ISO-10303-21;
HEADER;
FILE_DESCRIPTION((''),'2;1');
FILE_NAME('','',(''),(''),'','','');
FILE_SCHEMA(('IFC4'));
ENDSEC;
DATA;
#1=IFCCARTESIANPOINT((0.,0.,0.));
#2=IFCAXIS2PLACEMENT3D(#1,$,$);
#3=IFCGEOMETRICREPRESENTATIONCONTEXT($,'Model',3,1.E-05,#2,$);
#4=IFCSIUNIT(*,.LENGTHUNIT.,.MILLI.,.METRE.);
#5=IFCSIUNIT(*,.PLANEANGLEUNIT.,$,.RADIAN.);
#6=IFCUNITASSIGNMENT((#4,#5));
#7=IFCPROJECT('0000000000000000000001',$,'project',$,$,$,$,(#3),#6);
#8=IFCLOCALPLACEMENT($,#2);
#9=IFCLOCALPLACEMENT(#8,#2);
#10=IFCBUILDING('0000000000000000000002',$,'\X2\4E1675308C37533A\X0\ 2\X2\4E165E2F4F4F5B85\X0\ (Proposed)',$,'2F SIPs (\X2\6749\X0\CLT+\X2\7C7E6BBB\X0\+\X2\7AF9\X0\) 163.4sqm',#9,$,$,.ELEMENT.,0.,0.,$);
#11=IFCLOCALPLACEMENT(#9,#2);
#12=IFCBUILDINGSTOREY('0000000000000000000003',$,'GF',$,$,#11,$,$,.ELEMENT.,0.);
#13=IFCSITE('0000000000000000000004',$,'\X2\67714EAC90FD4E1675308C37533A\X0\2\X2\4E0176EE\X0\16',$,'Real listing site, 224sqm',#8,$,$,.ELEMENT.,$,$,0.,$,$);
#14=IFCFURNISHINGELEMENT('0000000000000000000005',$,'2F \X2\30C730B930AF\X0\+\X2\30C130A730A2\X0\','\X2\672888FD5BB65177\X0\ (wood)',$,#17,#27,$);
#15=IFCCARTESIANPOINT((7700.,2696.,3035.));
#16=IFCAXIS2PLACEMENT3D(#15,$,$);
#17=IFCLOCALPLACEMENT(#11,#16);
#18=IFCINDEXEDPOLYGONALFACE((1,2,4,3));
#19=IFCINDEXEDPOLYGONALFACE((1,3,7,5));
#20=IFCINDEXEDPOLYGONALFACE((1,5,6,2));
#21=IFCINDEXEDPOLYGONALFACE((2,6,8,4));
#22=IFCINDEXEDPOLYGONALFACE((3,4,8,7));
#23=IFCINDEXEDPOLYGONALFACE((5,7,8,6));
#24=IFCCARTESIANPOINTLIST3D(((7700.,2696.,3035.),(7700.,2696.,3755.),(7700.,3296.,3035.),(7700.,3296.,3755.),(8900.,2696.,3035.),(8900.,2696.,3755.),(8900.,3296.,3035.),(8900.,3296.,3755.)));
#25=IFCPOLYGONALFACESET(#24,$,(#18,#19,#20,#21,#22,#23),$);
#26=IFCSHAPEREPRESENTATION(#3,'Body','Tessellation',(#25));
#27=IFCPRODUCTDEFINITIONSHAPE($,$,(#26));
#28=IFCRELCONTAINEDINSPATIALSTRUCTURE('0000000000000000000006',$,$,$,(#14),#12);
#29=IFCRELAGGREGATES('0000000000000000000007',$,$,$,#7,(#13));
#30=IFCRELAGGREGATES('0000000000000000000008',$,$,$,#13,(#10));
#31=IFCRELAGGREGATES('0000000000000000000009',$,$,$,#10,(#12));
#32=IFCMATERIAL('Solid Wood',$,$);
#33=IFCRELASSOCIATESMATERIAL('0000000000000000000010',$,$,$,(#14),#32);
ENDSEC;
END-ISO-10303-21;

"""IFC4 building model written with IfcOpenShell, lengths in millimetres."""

from ifc_helpers import new_model, si_unit, frame, frame_2d, origin, place, context, project, spatial, rectangle, extrude, material, element, save


model = new_model("IFC4")

# Units and contexts
model_context = context("Model", 3, precision=1e-05, world=origin())
ifc_project = project(units=[si_unit("LENGTHUNIT", "METRE", prefix="MILLI"), si_unit("PLANEANGLEUNIT", "RADIAN")], contexts=[model_context])

# Site, building, storey
site_placement = place(None, origin())
site = spatial("IfcSite", under=ifc_project, at=site_placement, Name="東京都世田谷区2丁目16", ObjectType="Real listing site, 224sqm", CompositionType="ELEMENT", RefElevation=0.0)
building_placement = place(site_placement, origin())
building = spatial("IfcBuilding", under=site, at=building_placement, Name="世田谷区 2世帯住宅 (Proposed)", ObjectType="2F SIPs (杉CLT+籾殻+竹) 163.4sqm", CompositionType="ELEMENT", ElevationOfRefHeight=0.0, ElevationOfTerrain=0.0)
storey_placement = place(building_placement, origin())
storey = spatial("IfcBuildingStorey", under=building, at=storey_placement, Name="GF", CompositionType="ELEMENT", Elevation=0.0)

# Shared definitions
ifc_material_1 = material(Name="Solid Wood")

# Furnishing element
furnishing_1_placement = place(storey_placement, frame((7700.0, 2696.0, 3035.0)))
element("IfcFurnishingElement", 1, at=furnishing_1_placement, inside=storey, material=ifc_material_1, Name="2F デスク+チェア", Description="木製家具 (wood)", context=model_context, shape_type="SweptSolid", body=[
    extrude(rectangle(XDim=1200.0, YDim=600.0, at=frame_2d((600.0, 300.0))), frame((7700.0, 2696.0, 3035.0)), (0.0, 0.0, 1.0), 720.0),
])

save(model, "model.ifc")
